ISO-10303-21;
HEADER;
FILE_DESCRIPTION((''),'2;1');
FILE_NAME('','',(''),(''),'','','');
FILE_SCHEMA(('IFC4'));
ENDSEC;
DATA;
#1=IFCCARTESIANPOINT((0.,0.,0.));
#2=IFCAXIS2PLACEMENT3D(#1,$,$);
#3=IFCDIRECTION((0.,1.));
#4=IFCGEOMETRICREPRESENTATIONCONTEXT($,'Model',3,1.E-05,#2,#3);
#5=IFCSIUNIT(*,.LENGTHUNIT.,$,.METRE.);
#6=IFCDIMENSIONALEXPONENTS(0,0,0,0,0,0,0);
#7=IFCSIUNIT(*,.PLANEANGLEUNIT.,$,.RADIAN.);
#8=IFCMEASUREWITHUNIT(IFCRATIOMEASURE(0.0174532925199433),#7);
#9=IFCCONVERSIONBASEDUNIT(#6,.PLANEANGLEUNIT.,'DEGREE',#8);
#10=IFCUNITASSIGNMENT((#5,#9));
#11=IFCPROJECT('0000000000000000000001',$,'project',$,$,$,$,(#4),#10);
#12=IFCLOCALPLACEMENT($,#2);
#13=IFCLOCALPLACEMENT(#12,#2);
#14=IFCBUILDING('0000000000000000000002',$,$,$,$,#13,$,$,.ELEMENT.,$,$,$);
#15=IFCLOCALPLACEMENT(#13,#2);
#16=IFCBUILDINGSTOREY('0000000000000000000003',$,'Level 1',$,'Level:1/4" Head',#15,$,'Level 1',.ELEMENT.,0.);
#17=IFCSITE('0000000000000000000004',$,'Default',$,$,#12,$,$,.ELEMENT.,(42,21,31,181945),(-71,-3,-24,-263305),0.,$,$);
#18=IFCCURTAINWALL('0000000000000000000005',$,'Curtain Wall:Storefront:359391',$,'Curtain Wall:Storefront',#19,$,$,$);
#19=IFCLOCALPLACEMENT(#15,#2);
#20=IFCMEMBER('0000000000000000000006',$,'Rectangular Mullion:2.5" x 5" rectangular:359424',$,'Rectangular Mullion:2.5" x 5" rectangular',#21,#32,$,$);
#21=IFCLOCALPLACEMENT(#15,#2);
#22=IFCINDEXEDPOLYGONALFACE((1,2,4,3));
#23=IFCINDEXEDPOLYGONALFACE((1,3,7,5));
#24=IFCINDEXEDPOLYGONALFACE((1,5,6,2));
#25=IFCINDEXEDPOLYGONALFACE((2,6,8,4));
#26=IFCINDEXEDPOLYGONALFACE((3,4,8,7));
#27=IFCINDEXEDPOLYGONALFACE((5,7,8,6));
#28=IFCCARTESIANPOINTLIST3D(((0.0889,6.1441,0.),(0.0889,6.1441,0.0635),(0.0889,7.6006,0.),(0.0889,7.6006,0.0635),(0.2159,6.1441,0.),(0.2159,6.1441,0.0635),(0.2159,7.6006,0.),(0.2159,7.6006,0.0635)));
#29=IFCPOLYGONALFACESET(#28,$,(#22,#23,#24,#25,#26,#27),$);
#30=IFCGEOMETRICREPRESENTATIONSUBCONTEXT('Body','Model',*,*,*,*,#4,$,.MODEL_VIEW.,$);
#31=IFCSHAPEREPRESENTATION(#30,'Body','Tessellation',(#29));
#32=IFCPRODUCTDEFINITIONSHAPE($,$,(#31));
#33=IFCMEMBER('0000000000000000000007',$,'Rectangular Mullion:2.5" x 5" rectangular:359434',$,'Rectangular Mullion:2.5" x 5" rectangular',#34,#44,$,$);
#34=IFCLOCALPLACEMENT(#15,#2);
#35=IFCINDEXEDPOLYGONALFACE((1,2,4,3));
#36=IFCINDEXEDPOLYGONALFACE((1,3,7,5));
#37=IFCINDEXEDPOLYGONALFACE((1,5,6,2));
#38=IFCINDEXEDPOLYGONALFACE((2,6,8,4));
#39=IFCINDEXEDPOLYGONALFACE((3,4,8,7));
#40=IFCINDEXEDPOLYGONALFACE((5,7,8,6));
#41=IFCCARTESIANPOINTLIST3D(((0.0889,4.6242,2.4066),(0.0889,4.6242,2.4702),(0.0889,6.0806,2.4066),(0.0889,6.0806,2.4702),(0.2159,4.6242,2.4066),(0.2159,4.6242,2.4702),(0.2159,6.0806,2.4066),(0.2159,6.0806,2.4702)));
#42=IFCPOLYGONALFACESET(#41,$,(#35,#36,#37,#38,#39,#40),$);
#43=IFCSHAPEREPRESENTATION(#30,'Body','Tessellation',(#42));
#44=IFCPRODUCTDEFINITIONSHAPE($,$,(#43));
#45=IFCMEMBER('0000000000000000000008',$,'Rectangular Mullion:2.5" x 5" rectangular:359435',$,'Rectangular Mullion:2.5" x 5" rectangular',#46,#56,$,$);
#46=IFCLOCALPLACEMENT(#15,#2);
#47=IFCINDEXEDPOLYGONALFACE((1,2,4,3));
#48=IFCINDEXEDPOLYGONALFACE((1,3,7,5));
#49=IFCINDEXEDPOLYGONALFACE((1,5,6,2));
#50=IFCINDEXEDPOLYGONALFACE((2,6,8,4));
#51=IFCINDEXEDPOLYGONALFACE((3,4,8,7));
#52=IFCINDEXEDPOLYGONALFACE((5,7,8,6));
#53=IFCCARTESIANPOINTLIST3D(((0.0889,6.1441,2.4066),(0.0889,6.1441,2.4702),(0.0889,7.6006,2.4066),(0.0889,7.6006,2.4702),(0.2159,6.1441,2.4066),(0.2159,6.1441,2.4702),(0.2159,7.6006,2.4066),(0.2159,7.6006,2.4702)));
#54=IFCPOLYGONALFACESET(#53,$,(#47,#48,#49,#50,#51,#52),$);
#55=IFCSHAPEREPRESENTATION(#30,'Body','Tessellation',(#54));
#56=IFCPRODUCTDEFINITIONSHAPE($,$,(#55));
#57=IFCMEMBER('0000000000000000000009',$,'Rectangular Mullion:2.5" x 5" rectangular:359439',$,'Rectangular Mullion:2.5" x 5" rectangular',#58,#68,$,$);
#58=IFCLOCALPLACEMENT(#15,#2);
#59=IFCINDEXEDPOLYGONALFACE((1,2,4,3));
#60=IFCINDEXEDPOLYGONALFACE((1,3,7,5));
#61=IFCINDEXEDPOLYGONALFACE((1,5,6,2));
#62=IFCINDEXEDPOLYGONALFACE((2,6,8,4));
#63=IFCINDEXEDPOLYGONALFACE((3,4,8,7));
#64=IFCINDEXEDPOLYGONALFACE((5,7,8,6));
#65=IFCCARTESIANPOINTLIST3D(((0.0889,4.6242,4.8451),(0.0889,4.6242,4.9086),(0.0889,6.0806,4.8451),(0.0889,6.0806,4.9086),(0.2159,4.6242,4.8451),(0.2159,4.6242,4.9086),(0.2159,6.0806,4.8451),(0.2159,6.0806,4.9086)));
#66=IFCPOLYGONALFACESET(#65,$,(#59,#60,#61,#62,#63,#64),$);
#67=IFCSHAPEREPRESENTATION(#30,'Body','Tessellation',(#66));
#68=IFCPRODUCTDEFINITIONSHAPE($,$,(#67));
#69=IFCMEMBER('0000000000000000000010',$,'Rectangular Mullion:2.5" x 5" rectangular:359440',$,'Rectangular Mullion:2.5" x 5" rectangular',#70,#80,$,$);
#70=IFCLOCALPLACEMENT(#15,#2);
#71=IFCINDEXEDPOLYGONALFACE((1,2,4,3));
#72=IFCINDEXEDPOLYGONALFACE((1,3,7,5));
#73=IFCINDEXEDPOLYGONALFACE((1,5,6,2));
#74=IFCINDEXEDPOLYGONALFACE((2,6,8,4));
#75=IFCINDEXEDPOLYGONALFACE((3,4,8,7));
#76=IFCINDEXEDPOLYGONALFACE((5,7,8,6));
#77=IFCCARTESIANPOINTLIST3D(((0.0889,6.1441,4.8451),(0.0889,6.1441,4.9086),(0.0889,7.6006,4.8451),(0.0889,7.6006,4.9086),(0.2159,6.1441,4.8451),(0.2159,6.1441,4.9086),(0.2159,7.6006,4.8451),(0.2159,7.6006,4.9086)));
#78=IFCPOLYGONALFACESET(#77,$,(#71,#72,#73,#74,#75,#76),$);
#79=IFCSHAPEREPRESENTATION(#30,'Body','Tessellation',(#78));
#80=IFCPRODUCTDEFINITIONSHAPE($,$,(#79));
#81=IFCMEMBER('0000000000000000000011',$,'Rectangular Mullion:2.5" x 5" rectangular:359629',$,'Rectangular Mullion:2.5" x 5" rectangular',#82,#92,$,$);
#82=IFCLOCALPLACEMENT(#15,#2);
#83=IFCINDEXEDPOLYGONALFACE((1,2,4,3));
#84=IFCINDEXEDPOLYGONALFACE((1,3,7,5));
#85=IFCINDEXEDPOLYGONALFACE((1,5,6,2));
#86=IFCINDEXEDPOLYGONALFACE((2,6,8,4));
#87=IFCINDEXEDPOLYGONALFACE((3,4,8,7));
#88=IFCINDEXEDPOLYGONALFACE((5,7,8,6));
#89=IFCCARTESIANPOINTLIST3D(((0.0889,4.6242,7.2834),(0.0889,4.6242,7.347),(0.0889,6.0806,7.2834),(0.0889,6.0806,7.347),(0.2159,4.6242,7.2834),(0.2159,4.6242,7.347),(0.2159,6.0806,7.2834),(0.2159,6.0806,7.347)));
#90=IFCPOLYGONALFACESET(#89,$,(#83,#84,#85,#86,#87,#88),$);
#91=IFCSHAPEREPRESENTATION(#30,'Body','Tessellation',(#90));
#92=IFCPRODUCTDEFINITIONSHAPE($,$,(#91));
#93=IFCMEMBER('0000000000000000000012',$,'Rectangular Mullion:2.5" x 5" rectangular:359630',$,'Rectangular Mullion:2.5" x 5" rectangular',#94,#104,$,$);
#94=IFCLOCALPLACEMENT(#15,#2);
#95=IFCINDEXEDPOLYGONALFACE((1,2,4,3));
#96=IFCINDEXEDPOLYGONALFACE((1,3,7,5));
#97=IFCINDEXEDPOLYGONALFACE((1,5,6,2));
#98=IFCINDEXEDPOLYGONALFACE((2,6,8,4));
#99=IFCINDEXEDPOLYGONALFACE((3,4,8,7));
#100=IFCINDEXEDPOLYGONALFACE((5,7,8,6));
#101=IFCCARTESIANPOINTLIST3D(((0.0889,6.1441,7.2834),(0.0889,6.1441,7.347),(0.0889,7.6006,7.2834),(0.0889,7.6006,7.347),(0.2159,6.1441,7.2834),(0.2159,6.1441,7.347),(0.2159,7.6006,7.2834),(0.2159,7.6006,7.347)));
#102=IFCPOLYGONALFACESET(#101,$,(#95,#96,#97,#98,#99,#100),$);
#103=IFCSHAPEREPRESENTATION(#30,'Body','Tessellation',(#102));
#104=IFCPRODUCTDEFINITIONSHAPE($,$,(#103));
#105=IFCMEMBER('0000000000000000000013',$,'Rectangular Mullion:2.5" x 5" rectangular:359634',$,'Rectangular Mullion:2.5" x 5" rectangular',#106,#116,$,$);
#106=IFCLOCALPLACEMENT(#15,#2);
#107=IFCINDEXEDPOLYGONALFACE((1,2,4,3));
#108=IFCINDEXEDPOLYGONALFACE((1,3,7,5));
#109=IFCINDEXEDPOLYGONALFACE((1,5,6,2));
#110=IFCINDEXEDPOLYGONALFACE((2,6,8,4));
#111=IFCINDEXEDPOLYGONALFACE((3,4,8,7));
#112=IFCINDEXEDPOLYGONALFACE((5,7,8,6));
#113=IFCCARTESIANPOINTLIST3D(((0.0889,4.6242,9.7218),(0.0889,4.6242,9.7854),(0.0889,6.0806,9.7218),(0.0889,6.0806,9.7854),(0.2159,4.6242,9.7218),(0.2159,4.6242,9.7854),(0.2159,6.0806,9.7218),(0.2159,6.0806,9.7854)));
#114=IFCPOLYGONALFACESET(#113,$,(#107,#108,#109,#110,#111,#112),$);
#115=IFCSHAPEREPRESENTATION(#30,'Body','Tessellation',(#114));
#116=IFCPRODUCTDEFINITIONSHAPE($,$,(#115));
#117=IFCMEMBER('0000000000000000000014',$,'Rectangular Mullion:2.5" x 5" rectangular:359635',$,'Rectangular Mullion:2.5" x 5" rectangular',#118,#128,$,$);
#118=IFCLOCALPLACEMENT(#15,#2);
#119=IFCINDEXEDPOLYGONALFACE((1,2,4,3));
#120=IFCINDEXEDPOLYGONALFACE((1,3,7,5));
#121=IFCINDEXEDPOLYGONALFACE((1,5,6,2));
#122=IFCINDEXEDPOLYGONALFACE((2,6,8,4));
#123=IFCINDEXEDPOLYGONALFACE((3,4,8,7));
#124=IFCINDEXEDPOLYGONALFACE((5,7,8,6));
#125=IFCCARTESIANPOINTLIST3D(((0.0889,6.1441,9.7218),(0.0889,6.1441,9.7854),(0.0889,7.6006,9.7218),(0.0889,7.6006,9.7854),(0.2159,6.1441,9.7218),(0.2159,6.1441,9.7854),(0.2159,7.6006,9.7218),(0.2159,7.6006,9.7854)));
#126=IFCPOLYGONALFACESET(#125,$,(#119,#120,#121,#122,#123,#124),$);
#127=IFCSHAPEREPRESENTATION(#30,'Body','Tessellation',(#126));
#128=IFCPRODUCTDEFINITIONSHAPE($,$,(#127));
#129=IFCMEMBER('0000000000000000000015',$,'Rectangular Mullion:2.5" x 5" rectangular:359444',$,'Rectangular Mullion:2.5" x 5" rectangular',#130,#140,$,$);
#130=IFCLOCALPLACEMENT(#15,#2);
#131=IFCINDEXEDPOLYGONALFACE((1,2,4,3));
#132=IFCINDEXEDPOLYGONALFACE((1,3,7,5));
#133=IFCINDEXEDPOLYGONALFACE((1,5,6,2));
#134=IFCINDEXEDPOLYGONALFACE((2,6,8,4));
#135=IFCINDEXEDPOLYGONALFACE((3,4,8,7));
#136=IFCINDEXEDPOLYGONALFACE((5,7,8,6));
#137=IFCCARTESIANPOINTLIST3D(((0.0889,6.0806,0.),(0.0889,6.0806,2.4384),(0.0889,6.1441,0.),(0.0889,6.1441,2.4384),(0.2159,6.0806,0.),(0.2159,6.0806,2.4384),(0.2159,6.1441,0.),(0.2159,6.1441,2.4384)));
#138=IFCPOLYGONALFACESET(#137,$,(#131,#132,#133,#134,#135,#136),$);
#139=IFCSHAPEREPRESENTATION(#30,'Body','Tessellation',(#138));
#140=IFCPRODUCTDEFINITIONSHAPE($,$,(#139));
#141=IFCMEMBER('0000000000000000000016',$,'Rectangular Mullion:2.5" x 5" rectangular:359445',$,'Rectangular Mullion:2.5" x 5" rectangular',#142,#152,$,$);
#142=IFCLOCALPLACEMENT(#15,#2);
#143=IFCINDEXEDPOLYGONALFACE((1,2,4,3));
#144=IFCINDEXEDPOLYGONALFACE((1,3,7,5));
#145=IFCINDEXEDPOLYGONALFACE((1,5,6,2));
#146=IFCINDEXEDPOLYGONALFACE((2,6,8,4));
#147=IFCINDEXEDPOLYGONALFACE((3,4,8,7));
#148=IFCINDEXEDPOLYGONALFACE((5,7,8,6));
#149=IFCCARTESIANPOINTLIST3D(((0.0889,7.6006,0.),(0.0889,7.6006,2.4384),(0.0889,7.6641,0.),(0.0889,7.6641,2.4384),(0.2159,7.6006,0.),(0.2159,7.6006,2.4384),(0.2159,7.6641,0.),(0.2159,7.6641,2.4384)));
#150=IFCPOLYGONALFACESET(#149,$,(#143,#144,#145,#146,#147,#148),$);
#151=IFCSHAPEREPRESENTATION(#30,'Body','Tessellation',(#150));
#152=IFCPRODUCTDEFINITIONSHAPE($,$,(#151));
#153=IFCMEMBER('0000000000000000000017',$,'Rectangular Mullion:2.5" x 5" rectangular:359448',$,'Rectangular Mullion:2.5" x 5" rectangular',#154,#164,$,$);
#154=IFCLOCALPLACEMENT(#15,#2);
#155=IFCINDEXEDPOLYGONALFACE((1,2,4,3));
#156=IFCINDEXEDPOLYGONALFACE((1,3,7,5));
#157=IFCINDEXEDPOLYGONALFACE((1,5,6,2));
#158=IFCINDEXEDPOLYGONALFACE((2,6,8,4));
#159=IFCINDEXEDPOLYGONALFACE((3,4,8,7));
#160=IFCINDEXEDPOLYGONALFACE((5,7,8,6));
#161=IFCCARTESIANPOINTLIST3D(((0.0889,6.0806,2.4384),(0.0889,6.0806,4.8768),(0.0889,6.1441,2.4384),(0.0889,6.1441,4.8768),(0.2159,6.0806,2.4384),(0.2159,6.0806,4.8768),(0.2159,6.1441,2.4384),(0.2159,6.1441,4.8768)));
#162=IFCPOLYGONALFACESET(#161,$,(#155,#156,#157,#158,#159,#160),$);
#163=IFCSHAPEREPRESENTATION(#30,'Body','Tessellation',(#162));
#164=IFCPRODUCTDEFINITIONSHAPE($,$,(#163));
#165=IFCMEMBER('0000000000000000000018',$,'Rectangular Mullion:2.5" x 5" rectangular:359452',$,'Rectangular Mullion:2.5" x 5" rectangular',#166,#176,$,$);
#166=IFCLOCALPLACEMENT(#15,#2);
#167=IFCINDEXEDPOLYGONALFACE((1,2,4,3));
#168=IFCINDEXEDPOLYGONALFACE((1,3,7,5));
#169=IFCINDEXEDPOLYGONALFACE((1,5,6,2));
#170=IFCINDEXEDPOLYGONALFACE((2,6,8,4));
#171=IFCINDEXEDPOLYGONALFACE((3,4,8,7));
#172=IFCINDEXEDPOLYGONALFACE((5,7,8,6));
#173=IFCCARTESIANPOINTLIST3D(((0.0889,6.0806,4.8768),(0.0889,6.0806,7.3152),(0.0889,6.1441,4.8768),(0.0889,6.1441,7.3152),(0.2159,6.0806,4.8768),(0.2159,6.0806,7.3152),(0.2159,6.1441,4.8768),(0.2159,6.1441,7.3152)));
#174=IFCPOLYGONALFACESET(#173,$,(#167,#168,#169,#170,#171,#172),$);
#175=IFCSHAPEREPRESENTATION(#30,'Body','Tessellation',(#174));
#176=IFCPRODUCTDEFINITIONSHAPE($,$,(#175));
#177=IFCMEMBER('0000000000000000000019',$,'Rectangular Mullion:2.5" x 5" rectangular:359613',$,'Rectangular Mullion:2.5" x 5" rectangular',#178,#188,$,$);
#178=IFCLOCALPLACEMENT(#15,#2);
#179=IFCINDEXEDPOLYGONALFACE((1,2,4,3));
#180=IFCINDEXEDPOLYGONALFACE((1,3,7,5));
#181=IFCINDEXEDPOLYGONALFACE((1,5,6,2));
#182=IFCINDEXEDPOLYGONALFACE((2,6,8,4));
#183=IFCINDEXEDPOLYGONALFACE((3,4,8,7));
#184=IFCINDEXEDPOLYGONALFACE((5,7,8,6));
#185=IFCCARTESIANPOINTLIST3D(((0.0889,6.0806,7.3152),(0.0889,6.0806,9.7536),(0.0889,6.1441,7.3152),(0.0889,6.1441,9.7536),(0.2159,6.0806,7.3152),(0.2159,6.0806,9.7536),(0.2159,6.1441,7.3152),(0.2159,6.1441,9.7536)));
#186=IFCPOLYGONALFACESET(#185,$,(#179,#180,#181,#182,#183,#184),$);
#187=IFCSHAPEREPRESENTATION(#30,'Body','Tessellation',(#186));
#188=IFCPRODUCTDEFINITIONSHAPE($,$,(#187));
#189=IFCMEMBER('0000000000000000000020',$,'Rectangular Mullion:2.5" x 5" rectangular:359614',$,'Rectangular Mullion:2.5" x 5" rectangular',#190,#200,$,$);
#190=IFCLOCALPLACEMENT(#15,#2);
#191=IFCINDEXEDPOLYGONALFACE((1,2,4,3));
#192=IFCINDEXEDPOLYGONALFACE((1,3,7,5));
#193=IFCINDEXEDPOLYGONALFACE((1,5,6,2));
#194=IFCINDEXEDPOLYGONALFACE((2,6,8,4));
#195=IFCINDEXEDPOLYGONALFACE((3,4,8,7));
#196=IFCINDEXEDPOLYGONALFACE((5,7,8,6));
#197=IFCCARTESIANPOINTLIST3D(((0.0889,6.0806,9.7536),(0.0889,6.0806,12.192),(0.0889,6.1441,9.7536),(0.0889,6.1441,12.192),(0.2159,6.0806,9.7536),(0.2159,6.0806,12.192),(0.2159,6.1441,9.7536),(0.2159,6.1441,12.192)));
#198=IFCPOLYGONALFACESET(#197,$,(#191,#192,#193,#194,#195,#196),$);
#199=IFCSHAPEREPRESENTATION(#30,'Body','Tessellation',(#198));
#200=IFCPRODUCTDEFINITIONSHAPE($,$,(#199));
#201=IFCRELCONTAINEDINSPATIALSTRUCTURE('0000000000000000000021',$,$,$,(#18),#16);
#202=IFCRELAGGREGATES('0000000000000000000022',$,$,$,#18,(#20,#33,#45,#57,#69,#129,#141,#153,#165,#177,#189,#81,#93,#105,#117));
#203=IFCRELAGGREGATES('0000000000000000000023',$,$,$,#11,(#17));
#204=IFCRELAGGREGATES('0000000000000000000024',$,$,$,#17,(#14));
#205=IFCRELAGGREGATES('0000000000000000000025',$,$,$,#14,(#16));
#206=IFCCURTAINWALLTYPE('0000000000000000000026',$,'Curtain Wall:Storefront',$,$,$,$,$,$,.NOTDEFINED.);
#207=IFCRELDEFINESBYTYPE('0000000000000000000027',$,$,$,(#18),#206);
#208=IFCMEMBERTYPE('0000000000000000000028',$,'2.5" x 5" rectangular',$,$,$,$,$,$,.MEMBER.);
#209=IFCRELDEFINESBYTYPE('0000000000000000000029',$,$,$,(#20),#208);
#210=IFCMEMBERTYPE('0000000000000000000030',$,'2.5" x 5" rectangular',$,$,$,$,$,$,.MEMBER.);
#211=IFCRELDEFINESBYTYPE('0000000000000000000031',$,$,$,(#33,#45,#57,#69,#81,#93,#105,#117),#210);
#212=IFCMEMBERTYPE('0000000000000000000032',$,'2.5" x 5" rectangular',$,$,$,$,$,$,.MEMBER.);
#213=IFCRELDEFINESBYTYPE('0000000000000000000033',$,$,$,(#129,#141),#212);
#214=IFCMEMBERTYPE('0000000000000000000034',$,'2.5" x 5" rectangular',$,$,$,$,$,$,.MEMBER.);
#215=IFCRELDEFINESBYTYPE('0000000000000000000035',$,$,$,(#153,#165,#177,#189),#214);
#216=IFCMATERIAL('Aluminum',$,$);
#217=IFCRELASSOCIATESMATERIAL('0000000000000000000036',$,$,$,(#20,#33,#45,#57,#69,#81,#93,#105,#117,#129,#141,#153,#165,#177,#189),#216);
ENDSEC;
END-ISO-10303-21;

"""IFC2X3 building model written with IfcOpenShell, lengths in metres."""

from ifc_helpers import new_model, entity, si_unit, converted_unit, direction, frame, origin, origin_2d_with_axis, place, context, subcontext, project, spatial, rectangle, extrude, source, transform, mapped, material, type_object, type_shapes, element, aggregate, save


model = new_model("IFC2X3")

# Units and contexts
model_context = context("Model", 3, precision=1e-05, world=origin(), true_north=direction((0.0, 1.0)))
body_context = subcontext(model_context, "Body", "Model", "MODEL_VIEW")
ifc_project = project(units=[si_unit("LENGTHUNIT", "METRE"), converted_unit("PLANEANGLEUNIT", "DEGREE", entity("IfcRatioMeasure", 0.0174532925199433), si_unit("PLANEANGLEUNIT", "RADIAN"), dimensions=[0, 0, 0, 0, 0, 0, 0])], contexts=[model_context])

# Site, building, storey
site_placement = place(None, origin())
site = spatial("IfcSite", under=ifc_project, at=site_placement, Name="Default", CompositionType="ELEMENT", RefLatitude=(42, 21, 31, 181945), RefLongitude=(-71, -3, -24, -263305), RefElevation=0.0)
building_placement = place(site_placement, origin())
building = spatial("IfcBuilding", under=site, at=building_placement, CompositionType="ELEMENT")
storey_placement = place(building_placement, origin())
storey = spatial("IfcBuildingStorey", under=building, at=storey_placement, Name="Level 1", ObjectType="Level:1/4\" Head", LongName="Level 1", CompositionType="ELEMENT", Elevation=0.0)

# Curtain wall, members
curtain_wall_type = type_object("IfcCurtainWallType", Name="Curtain Wall:Storefront", PredefinedType="NOTDEFINED")
curtain_wall_placement = place(storey_placement, origin())
curtain_wall = element("IfcCurtainWall", 1, at=curtain_wall_placement, inside=storey, type_object=curtain_wall_type, Name="Curtain Wall:Storefront:359391", ObjectType="Curtain Wall:Storefront")
ifc_material_1 = material(Name="Aluminum")
member_type_1 = type_object("IfcMemberType", Name="2.5\" x 5\" rectangular", PredefinedType="MEMBER")
shared_shape_1 = source(origin(), body_context, "Body", "SweptSolid", [
    extrude(rectangle(XDim=0.127, YDim=0.0635, at=origin_2d_with_axis()), frame((-0.0318, 0.0, -1.4565), z_axis=(0.0, 0.0, 1.0), x_axis=(0.0, -1.0, 0.0)), (0.0, 0.0, 1.0), 1.4565),
])
type_shapes(member_type_1, [shared_shape_1])
member_1_placement = place(storey_placement, frame((0.1524, 6.1441, 0.0), z_axis=(0.0, -1.0, 0.0), x_axis=(0.0, 0.0, -1.0)))
member_1 = element("IfcMember", 2, at=member_1_placement, type_object=member_type_1, material=ifc_material_1, Name="Rectangular Mullion:2.5\" x 5\" rectangular:359424", ObjectType="Rectangular Mullion:2.5\" x 5\" rectangular", context=body_context, shape_type="MappedRepresentation", body=[
    mapped(shared_shape_1, transform((0.0, 0.0, 0.0), scale=1.0)),
])
member_type_2 = type_object("IfcMemberType", Name="2.5\" x 5\" rectangular", PredefinedType="MEMBER")
shared_shape_2 = source(origin(), body_context, "Body", "SweptSolid", [
    extrude(rectangle(XDim=0.127, YDim=0.0635, at=origin_2d_with_axis()), frame((0.0, 0.0, -1.4565), z_axis=(0.0, 0.0, 1.0), x_axis=(0.0, -1.0, 0.0)), (0.0, 0.0, 1.0), 1.4565),
])
type_shapes(member_type_2, [shared_shape_2])
member_2_placement = place(storey_placement, frame((0.1524, 6.0806, 2.4384), z_axis=(0.0, 1.0, 0.0), x_axis=(0.0, 0.0, 1.0)))
member_2 = element("IfcMember", 3, at=member_2_placement, type_object=member_type_2, material=ifc_material_1, Name="Rectangular Mullion:2.5\" x 5\" rectangular:359434", ObjectType="Rectangular Mullion:2.5\" x 5\" rectangular", context=body_context, shape_type="MappedRepresentation", body=[
    mapped(shared_shape_2, transform((0.0, 0.0, 0.0), scale=1.0)),
])
member_3_placement = place(storey_placement, frame((0.1524, 7.6006, 2.4384), z_axis=(0.0, 1.0, 0.0), x_axis=(0.0, 0.0, 1.0)))
member_3 = element("IfcMember", 4, at=member_3_placement, type_object=member_type_2, material=ifc_material_1, Name="Rectangular Mullion:2.5\" x 5\" rectangular:359435", ObjectType="Rectangular Mullion:2.5\" x 5\" rectangular", context=body_context, shape_type="MappedRepresentation", body=[
    mapped(shared_shape_2, transform((0.0, 0.0, 0.0), scale=1.0)),
])
member_4_placement = place(storey_placement, frame((0.1524, 6.0806, 4.8768), z_axis=(0.0, 1.0, 0.0), x_axis=(0.0, 0.0, 1.0)))
member_4 = element("IfcMember", 5, at=member_4_placement, type_object=member_type_2, material=ifc_material_1, Name="Rectangular Mullion:2.5\" x 5\" rectangular:359439", ObjectType="Rectangular Mullion:2.5\" x 5\" rectangular", context=body_context, shape_type="MappedRepresentation", body=[
    mapped(shared_shape_2, transform((0.0, 0.0, 0.0), scale=1.0)),
])
member_5_placement = place(storey_placement, frame((0.1524, 7.6006, 4.8768), z_axis=(0.0, 1.0, 0.0), x_axis=(0.0, 0.0, 1.0)))
member_5 = element("IfcMember", 6, at=member_5_placement, type_object=member_type_2, material=ifc_material_1, Name="Rectangular Mullion:2.5\" x 5\" rectangular:359440", ObjectType="Rectangular Mullion:2.5\" x 5\" rectangular", context=body_context, shape_type="MappedRepresentation", body=[
    mapped(shared_shape_2, transform((0.0, 0.0, 0.0), scale=1.0)),
])
member_6_placement = place(storey_placement, frame((0.1524, 6.0806, 7.3152), z_axis=(0.0, 1.0, 0.0), x_axis=(0.0, 0.0, 1.0)))
member_6 = element("IfcMember", 7, at=member_6_placement, type_object=member_type_2, material=ifc_material_1, Name="Rectangular Mullion:2.5\" x 5\" rectangular:359629", ObjectType="Rectangular Mullion:2.5\" x 5\" rectangular", context=body_context, shape_type="MappedRepresentation", body=[
    mapped(shared_shape_2, transform((0.0, 0.0, 0.0), scale=1.0)),
])
member_7_placement = place(storey_placement, frame((0.1524, 7.6006, 7.3152), z_axis=(0.0, 1.0, 0.0), x_axis=(0.0, 0.0, 1.0)))
member_7 = element("IfcMember", 8, at=member_7_placement, type_object=member_type_2, material=ifc_material_1, Name="Rectangular Mullion:2.5\" x 5\" rectangular:359630", ObjectType="Rectangular Mullion:2.5\" x 5\" rectangular", context=body_context, shape_type="MappedRepresentation", body=[
    mapped(shared_shape_2, transform((0.0, 0.0, 0.0), scale=1.0)),
])
member_8_placement = place(storey_placement, frame((0.1524, 6.0806, 9.7536), z_axis=(0.0, 1.0, 0.0), x_axis=(0.0, 0.0, 1.0)))
member_8 = element("IfcMember", 9, at=member_8_placement, type_object=member_type_2, material=ifc_material_1, Name="Rectangular Mullion:2.5\" x 5\" rectangular:359634", ObjectType="Rectangular Mullion:2.5\" x 5\" rectangular", context=body_context, shape_type="MappedRepresentation", body=[
    mapped(shared_shape_2, transform((0.0, 0.0, 0.0), scale=1.0)),
])
member_9_placement = place(storey_placement, frame((0.1524, 7.6006, 9.7536), z_axis=(0.0, 1.0, 0.0), x_axis=(0.0, 0.0, 1.0)))
member_9 = element("IfcMember", 10, at=member_9_placement, type_object=member_type_2, material=ifc_material_1, Name="Rectangular Mullion:2.5\" x 5\" rectangular:359635", ObjectType="Rectangular Mullion:2.5\" x 5\" rectangular", context=body_context, shape_type="MappedRepresentation", body=[
    mapped(shared_shape_2, transform((0.0, 0.0, 0.0), scale=1.0)),
])
member_type_3 = type_object("IfcMemberType", Name="2.5\" x 5\" rectangular", PredefinedType="MEMBER")
shared_shape_3 = source(origin(), body_context, "Body", "SweptSolid", [
    extrude(rectangle(XDim=0.127, YDim=0.0635, at=origin_2d_with_axis()), frame((0.0, 0.0, -2.4384), z_axis=(0.0, 0.0, 1.0), x_axis=(0.0, -1.0, 0.0)), (0.0, 0.0, 1.0), 2.4384),
])
type_shapes(member_type_3, [shared_shape_3])
member_10_placement = place(storey_placement, frame((0.1524, 6.1124, 0.0), z_axis=(0.0, 0.0, -1.0), x_axis=(0.0, 1.0, 0.0)))
member_10 = element("IfcMember", 11, at=member_10_placement, type_object=member_type_3, material=ifc_material_1, Name="Rectangular Mullion:2.5\" x 5\" rectangular:359444", ObjectType="Rectangular Mullion:2.5\" x 5\" rectangular", context=body_context, shape_type="MappedRepresentation", body=[
    mapped(shared_shape_3, transform((0.0, 0.0, 0.0), scale=1.0)),
])
member_11_placement = place(storey_placement, frame((0.1524, 7.6324, 0.0), z_axis=(0.0, 0.0, -1.0), x_axis=(0.0, 1.0, 0.0)))
member_11 = element("IfcMember", 12, at=member_11_placement, type_object=member_type_3, material=ifc_material_1, Name="Rectangular Mullion:2.5\" x 5\" rectangular:359445", ObjectType="Rectangular Mullion:2.5\" x 5\" rectangular", context=body_context, shape_type="MappedRepresentation", body=[
    mapped(shared_shape_3, transform((0.0, 0.0, 0.0), scale=1.0)),
])
member_type_4 = type_object("IfcMemberType", Name="2.5\" x 5\" rectangular", PredefinedType="MEMBER")
shared_shape_4 = source(origin(), body_context, "Body", "SweptSolid", [
    extrude(rectangle(XDim=0.127, YDim=0.0635, at=origin_2d_with_axis()), frame((0.0, 0.0, -2.4384), z_axis=(0.0, 0.0, 1.0), x_axis=(0.0, -1.0, 0.0)), (0.0, 0.0, 1.0), 2.4384),
])
type_shapes(member_type_4, [shared_shape_4])
member_12_placement = place(storey_placement, frame((0.1524, 6.1124, 2.4384), z_axis=(0.0, 0.0, -1.0), x_axis=(0.0, 1.0, 0.0)))
member_12 = element("IfcMember", 13, at=member_12_placement, type_object=member_type_4, material=ifc_material_1, Name="Rectangular Mullion:2.5\" x 5\" rectangular:359448", ObjectType="Rectangular Mullion:2.5\" x 5\" rectangular", context=body_context, shape_type="MappedRepresentation", body=[
    mapped(shared_shape_4, transform((0.0, 0.0, 0.0), scale=1.0)),
])
member_13_placement = place(storey_placement, frame((0.1524, 6.1124, 4.8768), z_axis=(0.0, 0.0, -1.0), x_axis=(0.0, 1.0, 0.0)))
member_13 = element("IfcMember", 14, at=member_13_placement, type_object=member_type_4, material=ifc_material_1, Name="Rectangular Mullion:2.5\" x 5\" rectangular:359452", ObjectType="Rectangular Mullion:2.5\" x 5\" rectangular", context=body_context, shape_type="MappedRepresentation", body=[
    mapped(shared_shape_4, transform((0.0, 0.0, 0.0), scale=1.0)),
])
member_14_placement = place(storey_placement, frame((0.1524, 6.1124, 7.3152), z_axis=(0.0, 0.0, -1.0), x_axis=(0.0, 1.0, 0.0)))
member_14 = element("IfcMember", 15, at=member_14_placement, type_object=member_type_4, material=ifc_material_1, Name="Rectangular Mullion:2.5\" x 5\" rectangular:359613", ObjectType="Rectangular Mullion:2.5\" x 5\" rectangular", context=body_context, shape_type="MappedRepresentation", body=[
    mapped(shared_shape_4, transform((0.0, 0.0, 0.0), scale=1.0)),
])
member_15_placement = place(storey_placement, frame((0.1524, 6.1124, 9.7536), z_axis=(0.0, 0.0, -1.0), x_axis=(0.0, 1.0, 0.0)))
member_15 = element("IfcMember", 16, at=member_15_placement, type_object=member_type_4, material=ifc_material_1, Name="Rectangular Mullion:2.5\" x 5\" rectangular:359614", ObjectType="Rectangular Mullion:2.5\" x 5\" rectangular", context=body_context, shape_type="MappedRepresentation", body=[
    mapped(shared_shape_4, transform((0.0, 0.0, 0.0), scale=1.0)),
])
aggregate(curtain_wall, [member_1, member_2, member_3, member_4, member_5, member_10, member_11, member_12, member_13, member_14, member_15, member_6, member_7, member_8, member_9])

save(model, "model.ifc")
